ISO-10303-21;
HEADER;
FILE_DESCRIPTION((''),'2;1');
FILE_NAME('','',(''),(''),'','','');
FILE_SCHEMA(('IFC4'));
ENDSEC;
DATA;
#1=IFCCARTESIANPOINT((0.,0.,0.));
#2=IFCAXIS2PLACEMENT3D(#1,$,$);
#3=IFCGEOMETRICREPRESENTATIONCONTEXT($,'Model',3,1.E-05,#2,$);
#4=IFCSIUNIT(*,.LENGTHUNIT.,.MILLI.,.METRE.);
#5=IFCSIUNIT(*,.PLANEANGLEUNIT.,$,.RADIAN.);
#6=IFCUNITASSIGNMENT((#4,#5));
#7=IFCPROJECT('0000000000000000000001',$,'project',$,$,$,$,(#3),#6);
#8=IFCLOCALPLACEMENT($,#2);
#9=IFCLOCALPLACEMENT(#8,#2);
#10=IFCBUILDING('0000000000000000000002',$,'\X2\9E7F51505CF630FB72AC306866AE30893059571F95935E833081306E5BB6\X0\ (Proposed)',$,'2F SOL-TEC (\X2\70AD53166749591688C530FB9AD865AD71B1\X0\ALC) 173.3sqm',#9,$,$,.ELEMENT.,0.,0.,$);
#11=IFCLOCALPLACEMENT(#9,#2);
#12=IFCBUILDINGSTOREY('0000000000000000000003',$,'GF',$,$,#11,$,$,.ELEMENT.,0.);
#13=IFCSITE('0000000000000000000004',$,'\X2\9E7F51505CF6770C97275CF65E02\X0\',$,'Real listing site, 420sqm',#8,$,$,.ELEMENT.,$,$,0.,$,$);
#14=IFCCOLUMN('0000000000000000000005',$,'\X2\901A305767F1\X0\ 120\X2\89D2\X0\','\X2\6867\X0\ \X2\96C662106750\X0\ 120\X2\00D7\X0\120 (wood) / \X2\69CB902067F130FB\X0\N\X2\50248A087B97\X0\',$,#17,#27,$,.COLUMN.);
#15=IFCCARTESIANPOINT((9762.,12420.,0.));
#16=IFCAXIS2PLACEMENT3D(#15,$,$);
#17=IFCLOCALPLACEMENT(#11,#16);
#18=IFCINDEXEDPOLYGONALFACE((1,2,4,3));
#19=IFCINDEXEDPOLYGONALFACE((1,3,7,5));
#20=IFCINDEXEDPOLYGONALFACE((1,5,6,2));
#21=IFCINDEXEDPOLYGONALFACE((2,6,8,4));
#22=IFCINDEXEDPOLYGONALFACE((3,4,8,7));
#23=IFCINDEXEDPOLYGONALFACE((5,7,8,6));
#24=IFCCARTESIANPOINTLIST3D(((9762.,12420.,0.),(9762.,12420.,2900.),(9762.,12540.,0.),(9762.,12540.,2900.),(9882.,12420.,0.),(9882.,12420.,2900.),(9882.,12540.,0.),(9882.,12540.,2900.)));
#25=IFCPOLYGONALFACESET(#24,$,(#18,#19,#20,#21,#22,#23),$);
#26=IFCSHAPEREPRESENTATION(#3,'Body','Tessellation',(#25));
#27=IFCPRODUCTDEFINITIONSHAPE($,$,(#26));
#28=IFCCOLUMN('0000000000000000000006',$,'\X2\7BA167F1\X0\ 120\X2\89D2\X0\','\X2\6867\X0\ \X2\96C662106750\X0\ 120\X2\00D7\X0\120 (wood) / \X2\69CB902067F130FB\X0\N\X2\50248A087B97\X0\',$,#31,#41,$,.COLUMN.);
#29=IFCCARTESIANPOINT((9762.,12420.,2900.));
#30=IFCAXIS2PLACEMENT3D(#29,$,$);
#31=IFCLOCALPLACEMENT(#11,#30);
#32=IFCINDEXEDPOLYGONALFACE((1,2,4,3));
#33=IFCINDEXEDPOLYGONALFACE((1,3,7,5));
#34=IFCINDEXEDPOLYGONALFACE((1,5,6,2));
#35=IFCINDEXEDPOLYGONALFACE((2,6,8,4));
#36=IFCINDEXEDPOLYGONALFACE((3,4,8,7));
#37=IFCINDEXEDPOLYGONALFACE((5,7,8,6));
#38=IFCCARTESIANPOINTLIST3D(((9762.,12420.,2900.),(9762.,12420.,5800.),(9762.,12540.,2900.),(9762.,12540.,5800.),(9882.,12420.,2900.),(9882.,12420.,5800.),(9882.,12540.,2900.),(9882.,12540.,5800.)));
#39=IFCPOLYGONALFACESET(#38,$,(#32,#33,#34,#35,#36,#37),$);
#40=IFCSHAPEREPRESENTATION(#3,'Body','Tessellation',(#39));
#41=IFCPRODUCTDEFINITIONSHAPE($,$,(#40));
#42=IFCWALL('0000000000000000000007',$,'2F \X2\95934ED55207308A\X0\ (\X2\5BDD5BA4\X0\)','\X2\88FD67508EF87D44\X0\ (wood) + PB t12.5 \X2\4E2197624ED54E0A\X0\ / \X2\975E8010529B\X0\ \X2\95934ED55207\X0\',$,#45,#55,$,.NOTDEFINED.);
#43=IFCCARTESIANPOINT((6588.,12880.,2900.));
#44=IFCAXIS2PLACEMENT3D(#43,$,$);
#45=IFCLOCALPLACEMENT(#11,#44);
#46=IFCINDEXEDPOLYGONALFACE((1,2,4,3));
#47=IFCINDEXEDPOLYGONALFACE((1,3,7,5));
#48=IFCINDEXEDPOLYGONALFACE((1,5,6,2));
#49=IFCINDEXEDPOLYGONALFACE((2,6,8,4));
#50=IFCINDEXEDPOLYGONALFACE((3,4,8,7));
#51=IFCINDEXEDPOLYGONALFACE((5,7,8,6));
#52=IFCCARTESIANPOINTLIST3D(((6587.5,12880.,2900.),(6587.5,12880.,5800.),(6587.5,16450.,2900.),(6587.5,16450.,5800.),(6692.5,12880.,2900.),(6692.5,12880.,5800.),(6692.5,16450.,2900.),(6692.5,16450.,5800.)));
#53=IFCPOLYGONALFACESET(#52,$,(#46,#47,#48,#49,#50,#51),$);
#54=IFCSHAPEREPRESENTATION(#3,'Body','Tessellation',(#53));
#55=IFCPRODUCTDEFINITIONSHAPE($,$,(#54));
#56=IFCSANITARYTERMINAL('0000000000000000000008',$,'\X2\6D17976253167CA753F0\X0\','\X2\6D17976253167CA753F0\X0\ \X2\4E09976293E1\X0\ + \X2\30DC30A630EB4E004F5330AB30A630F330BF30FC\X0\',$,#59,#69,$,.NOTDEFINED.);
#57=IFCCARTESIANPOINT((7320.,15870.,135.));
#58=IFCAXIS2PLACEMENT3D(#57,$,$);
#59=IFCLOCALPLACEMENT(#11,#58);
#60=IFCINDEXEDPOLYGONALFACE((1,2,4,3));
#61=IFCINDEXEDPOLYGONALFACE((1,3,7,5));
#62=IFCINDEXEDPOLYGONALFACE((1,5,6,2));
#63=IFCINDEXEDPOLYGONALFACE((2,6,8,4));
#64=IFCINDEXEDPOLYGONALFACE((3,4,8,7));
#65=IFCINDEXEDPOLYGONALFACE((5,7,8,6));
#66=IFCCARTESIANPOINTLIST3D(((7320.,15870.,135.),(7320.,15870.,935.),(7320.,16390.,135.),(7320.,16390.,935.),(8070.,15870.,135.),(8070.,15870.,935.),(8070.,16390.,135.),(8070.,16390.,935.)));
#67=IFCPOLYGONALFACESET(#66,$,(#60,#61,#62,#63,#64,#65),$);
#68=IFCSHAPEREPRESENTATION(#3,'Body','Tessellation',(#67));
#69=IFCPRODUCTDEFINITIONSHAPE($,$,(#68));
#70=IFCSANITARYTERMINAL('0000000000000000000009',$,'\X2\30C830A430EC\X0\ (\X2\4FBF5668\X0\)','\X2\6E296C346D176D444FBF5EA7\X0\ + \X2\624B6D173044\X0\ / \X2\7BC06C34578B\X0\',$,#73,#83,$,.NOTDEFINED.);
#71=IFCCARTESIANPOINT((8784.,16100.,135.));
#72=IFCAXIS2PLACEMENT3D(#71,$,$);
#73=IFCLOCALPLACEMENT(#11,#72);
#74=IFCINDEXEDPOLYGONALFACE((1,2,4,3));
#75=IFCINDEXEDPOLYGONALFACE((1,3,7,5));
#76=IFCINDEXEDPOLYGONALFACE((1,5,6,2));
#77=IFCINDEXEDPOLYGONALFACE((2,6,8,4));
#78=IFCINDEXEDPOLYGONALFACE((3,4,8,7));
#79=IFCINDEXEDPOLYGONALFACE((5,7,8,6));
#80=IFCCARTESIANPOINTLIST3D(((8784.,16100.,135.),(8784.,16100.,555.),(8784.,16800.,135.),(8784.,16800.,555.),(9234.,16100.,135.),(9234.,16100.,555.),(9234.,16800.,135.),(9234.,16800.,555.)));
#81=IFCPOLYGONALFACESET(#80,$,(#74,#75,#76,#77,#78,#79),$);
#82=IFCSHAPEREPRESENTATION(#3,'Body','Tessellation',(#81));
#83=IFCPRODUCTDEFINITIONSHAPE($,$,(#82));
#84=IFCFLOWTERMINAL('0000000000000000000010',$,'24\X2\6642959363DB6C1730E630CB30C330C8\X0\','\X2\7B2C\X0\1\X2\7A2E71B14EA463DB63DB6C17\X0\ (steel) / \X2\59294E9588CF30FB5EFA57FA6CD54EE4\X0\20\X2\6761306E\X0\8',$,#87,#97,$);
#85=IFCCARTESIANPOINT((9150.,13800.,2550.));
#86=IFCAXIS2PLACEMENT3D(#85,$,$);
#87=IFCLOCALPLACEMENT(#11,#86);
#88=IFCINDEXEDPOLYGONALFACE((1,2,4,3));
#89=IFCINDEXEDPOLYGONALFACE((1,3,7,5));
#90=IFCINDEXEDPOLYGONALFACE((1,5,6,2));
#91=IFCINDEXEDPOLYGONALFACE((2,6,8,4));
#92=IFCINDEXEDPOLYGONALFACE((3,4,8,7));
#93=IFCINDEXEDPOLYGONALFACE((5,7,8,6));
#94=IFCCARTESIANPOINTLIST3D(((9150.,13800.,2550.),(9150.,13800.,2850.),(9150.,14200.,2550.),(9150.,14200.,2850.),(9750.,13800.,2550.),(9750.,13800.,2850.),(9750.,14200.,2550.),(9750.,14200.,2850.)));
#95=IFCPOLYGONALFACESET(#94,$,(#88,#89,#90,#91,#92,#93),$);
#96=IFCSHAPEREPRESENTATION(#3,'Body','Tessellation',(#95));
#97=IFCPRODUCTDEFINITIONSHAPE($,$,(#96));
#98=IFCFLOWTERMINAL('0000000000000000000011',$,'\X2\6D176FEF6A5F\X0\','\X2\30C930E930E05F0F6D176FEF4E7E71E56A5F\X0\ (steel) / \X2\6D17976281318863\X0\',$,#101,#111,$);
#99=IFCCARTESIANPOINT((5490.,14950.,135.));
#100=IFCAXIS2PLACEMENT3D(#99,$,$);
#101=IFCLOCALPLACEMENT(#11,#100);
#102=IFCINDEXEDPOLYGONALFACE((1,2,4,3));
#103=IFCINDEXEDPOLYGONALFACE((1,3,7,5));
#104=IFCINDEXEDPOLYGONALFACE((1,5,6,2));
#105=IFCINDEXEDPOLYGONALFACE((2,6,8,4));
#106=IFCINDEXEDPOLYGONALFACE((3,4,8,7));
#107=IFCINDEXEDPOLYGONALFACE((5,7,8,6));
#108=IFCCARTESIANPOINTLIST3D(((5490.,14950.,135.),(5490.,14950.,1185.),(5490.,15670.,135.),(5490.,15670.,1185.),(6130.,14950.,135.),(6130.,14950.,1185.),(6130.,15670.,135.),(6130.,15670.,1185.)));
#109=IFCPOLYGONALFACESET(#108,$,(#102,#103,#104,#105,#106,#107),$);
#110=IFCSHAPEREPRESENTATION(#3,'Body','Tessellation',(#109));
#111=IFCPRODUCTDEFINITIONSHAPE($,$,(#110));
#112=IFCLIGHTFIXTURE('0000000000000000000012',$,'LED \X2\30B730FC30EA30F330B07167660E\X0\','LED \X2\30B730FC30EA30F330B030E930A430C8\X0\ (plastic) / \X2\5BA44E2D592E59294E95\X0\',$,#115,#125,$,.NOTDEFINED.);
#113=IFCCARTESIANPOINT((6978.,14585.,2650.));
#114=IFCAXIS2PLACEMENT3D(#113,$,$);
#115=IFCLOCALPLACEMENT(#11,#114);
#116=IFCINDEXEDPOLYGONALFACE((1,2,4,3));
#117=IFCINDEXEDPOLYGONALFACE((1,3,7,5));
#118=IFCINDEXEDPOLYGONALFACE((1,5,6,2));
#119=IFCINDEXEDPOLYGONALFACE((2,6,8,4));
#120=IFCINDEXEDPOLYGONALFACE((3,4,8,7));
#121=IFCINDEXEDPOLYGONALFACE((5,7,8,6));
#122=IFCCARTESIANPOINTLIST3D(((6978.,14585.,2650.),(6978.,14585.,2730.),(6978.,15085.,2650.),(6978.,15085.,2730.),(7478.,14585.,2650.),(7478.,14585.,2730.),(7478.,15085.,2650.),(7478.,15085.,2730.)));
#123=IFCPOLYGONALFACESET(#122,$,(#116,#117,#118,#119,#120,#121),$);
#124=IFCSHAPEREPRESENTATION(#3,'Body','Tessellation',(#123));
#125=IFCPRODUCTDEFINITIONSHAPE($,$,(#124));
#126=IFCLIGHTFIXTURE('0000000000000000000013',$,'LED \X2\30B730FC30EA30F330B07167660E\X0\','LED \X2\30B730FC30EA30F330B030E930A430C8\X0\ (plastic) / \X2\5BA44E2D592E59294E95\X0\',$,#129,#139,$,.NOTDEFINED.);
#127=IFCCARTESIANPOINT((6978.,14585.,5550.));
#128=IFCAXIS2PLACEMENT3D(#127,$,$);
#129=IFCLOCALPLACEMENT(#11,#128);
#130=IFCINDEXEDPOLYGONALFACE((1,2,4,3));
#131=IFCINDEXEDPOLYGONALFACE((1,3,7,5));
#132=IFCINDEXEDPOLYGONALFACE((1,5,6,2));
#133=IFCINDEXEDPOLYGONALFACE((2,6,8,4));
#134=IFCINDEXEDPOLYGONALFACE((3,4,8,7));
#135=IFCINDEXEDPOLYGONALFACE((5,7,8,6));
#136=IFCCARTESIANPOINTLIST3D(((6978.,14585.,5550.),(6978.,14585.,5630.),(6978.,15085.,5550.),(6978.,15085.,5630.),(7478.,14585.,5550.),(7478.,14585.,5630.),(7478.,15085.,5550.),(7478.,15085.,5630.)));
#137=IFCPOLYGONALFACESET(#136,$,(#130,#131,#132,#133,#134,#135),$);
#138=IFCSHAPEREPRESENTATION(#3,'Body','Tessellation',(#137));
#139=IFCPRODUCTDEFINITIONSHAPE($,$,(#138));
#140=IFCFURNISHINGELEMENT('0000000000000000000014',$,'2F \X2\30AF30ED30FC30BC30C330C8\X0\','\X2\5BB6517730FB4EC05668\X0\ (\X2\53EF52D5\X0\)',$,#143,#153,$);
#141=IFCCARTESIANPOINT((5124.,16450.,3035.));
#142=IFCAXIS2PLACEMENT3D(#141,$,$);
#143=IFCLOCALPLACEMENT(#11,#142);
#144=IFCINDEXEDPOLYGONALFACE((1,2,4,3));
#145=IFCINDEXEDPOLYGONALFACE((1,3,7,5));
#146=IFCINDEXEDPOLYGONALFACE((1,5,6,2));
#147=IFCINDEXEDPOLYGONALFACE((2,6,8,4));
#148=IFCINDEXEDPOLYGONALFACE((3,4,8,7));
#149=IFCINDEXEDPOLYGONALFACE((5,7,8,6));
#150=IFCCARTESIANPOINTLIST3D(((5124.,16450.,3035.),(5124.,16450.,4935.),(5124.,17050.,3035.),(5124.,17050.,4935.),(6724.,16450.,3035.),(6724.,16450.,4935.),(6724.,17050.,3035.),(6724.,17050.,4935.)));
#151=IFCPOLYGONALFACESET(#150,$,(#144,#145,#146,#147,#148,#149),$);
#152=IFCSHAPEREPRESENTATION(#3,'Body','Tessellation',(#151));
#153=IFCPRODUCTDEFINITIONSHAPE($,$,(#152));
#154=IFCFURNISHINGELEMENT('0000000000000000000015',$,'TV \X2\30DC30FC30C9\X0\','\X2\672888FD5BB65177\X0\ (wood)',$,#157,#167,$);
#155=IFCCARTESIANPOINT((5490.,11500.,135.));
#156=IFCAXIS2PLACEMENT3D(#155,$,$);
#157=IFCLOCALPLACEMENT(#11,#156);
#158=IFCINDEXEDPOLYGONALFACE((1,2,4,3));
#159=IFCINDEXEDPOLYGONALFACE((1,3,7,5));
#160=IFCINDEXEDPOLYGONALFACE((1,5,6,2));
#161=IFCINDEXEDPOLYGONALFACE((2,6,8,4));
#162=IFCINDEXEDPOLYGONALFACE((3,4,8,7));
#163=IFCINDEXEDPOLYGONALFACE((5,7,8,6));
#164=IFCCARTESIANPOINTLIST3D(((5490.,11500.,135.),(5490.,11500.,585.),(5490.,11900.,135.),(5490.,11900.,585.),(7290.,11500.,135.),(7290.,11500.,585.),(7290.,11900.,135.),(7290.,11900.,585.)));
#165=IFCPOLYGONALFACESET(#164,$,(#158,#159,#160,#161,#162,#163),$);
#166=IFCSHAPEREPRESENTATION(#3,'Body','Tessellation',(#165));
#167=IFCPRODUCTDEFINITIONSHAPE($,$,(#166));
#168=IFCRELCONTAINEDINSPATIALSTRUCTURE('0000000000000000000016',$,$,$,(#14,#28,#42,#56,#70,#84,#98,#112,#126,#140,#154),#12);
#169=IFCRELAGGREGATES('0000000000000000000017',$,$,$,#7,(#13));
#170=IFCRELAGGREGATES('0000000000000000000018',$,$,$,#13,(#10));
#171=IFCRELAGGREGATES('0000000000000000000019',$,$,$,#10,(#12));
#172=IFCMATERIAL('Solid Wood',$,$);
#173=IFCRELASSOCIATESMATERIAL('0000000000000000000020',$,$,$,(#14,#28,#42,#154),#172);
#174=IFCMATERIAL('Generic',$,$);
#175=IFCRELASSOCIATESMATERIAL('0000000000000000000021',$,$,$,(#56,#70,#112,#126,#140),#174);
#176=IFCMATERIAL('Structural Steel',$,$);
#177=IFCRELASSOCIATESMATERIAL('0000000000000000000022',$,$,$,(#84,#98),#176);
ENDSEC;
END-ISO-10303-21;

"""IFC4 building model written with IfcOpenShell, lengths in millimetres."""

from ifc_helpers import new_model, si_unit, frame, frame_2d, origin, place, context, project, spatial, rectangle, extrude, material, element, save


model = new_model("IFC4")

# Units and contexts
model_context = context("Model", 3, precision=1e-05, world=origin())
ifc_project = project(units=[si_unit("LENGTHUNIT", "METRE", prefix="MILLI"), si_unit("PLANEANGLEUNIT", "RADIAN")], contexts=[model_context])

# Site, building, storey
site_placement = place(None, origin())
site = spatial("IfcSite", under=ifc_project, at=site_placement, Name="鹿児島県霧島市", ObjectType="Real listing site, 420sqm", CompositionType="ELEMENT", RefElevation=0.0)
building_placement = place(site_placement, origin())
building = spatial("IfcBuilding", under=site, at=building_placement, Name="鹿児島・犬と暮らす土間広めの家 (Proposed)", ObjectType="2F SOL-TEC (炭化杉外装・高断熱ALC) 173.3sqm", CompositionType="ELEMENT", ElevationOfRefHeight=0.0, ElevationOfTerrain=0.0)
storey_placement = place(building_placement, origin())
storey = spatial("IfcBuildingStorey", under=building, at=storey_placement, Name="GF", CompositionType="ELEMENT", Elevation=0.0)

# Columns
ifc_material_1 = material(Name="Solid Wood")
column_1_placement = place(storey_placement, frame((9762.0, 12420.0, 0.0)))
element("IfcColumn", 1, at=column_1_placement, inside=storey, material=ifc_material_1, Name="通し柱 120角", Description="桧 集成材 120×120 (wood) / 構造柱・N値計算", PredefinedType="COLUMN", context=model_context, shape_type="SweptSolid", body=[
    extrude(rectangle(XDim=120.0, YDim=120.0, at=frame_2d((60.0, 60.0))), frame((9762.0, 12420.0, 0.0)), (0.0, 0.0, 1.0), 2900.0),
])
column_2_placement = place(storey_placement, frame((9762.0, 12420.0, 2900.0)))
element("IfcColumn", 2, at=column_2_placement, inside=storey, material=ifc_material_1, Name="管柱 120角", Description="桧 集成材 120×120 (wood) / 構造柱・N値計算", PredefinedType="COLUMN", context=model_context, shape_type="SweptSolid", body=[
    extrude(rectangle(XDim=120.0, YDim=120.0, at=frame_2d((60.0, 60.0))), frame((9762.0, 12420.0, 2900.0)), (0.0, 0.0, 1.0), 2900.0),
])

# Wall
wall_1_placement = place(storey_placement, frame((6588.0, 12880.0, 2900.0)))
element("IfcWall", 3, at=wall_1_placement, inside=storey, material=ifc_material_1, Name="2F 間仕切り (寝室)", Description="製材軸組 (wood) + PB t12.5 両面仕上 / 非耐力 間仕切", PredefinedType="NOTDEFINED", context=model_context, shape_type="SweptSolid", body=[
    extrude(rectangle(XDim=105.0, YDim=3570.0, at=frame_2d((52.0, 1785.0))), frame((6588.0, 12880.0, 2900.0)), (0.0, 0.0, 1.0), 2900.0),
])

# Sanitary terminals
ifc_material_2 = material(Name="Generic")
sanitary_terminal_1_placement = place(storey_placement, frame((7320.0, 15870.0, 135.0)))
element("IfcSanitaryTerminal", 4, at=sanitary_terminal_1_placement, inside=storey, material=ifc_material_2, Name="洗面化粧台", Description="洗面化粧台 三面鏡 + ボウル一体カウンター", PredefinedType="NOTDEFINED", context=model_context, shape_type="SweptSolid", body=[
    extrude(rectangle(XDim=750.0, YDim=520.0, at=frame_2d((375.0, 260.0))), frame((7320.0, 15870.0, 135.0)), (0.0, 0.0, 1.0), 800.0),
])
sanitary_terminal_2_placement = place(storey_placement, frame((8784.0, 16100.0, 135.0)))
element("IfcSanitaryTerminal", 5, at=sanitary_terminal_2_placement, inside=storey, material=ifc_material_2, Name="トイレ (便器)", Description="温水洗浄便座 + 手洗い / 節水型", PredefinedType="NOTDEFINED", context=model_context, shape_type="SweptSolid", body=[
    extrude(rectangle(XDim=450.0, YDim=700.0, at=frame_2d((225.0, 350.0))), frame((8784.0, 16100.0, 135.0)), (0.0, 0.0, 1.0), 420.0),
])

# Flow terminals
ifc_material_3 = material(Name="Structural Steel")
flow_terminal_1_placement = place(storey_placement, frame((9150.0, 13800.0, 2550.0)))
element("IfcFlowTerminal", 6, at=flow_terminal_1_placement, inside=storey, material=ifc_material_3, Name="24時間換気ユニット", Description="第1種熱交換換気 (steel) / 天井裏・建基法令20条の8", context=model_context, shape_type="SweptSolid", body=[
    extrude(rectangle(XDim=600.0, YDim=400.0, at=frame_2d((300.0, 200.0))), frame((9150.0, 13800.0, 2550.0)), (0.0, 0.0, 1.0), 300.0),
])
flow_terminal_2_placement = place(storey_placement, frame((5490.0, 14950.0, 135.0)))
element("IfcFlowTerminal", 7, at=flow_terminal_2_placement, inside=storey, material=ifc_material_3, Name="洗濯機", Description="ドラム式洗濯乾燥機 (steel) / 洗面脱衣", context=model_context, shape_type="SweptSolid", body=[
    extrude(rectangle(XDim=640.0, YDim=720.0, at=frame_2d((320.0, 360.0))), frame((5490.0, 14950.0, 135.0)), (0.0, 0.0, 1.0), 1050.0),
])

# Light fixtures
light_fixture_1_placement = place(storey_placement, frame((6978.0, 14585.0, 2650.0)))
element("IfcLightFixture", 8, at=light_fixture_1_placement, inside=storey, material=ifc_material_2, Name="LED シーリング照明", Description="LED シーリングライト (plastic) / 室中央天井", PredefinedType="NOTDEFINED", context=model_context, shape_type="SweptSolid", body=[
    extrude(rectangle(XDim=500.0, YDim=500.0, at=frame_2d((250.0, 250.0))), frame((6978.0, 14585.0, 2650.0)), (0.0, 0.0, 1.0), 80.0),
])
light_fixture_2_placement = place(storey_placement, frame((6978.0, 14585.0, 5550.0)))
element("IfcLightFixture", 9, at=light_fixture_2_placement, inside=storey, material=ifc_material_2, Name="LED シーリング照明", Description="LED シーリングライト (plastic) / 室中央天井", PredefinedType="NOTDEFINED", context=model_context, shape_type="SweptSolid", body=[
    extrude(rectangle(XDim=500.0, YDim=500.0, at=frame_2d((250.0, 250.0))), frame((6978.0, 14585.0, 5550.0)), (0.0, 0.0, 1.0), 80.0),
])

# Furnishing elements
furnishing_1_placement = place(storey_placement, frame((5124.0, 16450.0, 3035.0)))
element("IfcFurnishingElement", 10, at=furnishing_1_placement, inside=storey, material=ifc_material_2, Name="2F クローゼット", Description="家具・什器 (可動)", context=model_context, shape_type="SweptSolid", body=[
    extrude(rectangle(XDim=1600.0, YDim=600.0, at=frame_2d((800.0, 300.0))), frame((5124.0, 16450.0, 3035.0)), (0.0, 0.0, 1.0), 1900.0),
])
furnishing_2_placement = place(storey_placement, frame((5490.0, 11500.0, 135.0)))
element("IfcFurnishingElement", 11, at=furnishing_2_placement, inside=storey, material=ifc_material_1, Name="TV ボード", Description="木製家具 (wood)", context=model_context, shape_type="SweptSolid", body=[
    extrude(rectangle(XDim=1800.0, YDim=400.0, at=frame_2d((900.0, 200.0))), frame((5490.0, 11500.0, 135.0)), (0.0, 0.0, 1.0), 450.0),
])

save(model, "model.ifc")
